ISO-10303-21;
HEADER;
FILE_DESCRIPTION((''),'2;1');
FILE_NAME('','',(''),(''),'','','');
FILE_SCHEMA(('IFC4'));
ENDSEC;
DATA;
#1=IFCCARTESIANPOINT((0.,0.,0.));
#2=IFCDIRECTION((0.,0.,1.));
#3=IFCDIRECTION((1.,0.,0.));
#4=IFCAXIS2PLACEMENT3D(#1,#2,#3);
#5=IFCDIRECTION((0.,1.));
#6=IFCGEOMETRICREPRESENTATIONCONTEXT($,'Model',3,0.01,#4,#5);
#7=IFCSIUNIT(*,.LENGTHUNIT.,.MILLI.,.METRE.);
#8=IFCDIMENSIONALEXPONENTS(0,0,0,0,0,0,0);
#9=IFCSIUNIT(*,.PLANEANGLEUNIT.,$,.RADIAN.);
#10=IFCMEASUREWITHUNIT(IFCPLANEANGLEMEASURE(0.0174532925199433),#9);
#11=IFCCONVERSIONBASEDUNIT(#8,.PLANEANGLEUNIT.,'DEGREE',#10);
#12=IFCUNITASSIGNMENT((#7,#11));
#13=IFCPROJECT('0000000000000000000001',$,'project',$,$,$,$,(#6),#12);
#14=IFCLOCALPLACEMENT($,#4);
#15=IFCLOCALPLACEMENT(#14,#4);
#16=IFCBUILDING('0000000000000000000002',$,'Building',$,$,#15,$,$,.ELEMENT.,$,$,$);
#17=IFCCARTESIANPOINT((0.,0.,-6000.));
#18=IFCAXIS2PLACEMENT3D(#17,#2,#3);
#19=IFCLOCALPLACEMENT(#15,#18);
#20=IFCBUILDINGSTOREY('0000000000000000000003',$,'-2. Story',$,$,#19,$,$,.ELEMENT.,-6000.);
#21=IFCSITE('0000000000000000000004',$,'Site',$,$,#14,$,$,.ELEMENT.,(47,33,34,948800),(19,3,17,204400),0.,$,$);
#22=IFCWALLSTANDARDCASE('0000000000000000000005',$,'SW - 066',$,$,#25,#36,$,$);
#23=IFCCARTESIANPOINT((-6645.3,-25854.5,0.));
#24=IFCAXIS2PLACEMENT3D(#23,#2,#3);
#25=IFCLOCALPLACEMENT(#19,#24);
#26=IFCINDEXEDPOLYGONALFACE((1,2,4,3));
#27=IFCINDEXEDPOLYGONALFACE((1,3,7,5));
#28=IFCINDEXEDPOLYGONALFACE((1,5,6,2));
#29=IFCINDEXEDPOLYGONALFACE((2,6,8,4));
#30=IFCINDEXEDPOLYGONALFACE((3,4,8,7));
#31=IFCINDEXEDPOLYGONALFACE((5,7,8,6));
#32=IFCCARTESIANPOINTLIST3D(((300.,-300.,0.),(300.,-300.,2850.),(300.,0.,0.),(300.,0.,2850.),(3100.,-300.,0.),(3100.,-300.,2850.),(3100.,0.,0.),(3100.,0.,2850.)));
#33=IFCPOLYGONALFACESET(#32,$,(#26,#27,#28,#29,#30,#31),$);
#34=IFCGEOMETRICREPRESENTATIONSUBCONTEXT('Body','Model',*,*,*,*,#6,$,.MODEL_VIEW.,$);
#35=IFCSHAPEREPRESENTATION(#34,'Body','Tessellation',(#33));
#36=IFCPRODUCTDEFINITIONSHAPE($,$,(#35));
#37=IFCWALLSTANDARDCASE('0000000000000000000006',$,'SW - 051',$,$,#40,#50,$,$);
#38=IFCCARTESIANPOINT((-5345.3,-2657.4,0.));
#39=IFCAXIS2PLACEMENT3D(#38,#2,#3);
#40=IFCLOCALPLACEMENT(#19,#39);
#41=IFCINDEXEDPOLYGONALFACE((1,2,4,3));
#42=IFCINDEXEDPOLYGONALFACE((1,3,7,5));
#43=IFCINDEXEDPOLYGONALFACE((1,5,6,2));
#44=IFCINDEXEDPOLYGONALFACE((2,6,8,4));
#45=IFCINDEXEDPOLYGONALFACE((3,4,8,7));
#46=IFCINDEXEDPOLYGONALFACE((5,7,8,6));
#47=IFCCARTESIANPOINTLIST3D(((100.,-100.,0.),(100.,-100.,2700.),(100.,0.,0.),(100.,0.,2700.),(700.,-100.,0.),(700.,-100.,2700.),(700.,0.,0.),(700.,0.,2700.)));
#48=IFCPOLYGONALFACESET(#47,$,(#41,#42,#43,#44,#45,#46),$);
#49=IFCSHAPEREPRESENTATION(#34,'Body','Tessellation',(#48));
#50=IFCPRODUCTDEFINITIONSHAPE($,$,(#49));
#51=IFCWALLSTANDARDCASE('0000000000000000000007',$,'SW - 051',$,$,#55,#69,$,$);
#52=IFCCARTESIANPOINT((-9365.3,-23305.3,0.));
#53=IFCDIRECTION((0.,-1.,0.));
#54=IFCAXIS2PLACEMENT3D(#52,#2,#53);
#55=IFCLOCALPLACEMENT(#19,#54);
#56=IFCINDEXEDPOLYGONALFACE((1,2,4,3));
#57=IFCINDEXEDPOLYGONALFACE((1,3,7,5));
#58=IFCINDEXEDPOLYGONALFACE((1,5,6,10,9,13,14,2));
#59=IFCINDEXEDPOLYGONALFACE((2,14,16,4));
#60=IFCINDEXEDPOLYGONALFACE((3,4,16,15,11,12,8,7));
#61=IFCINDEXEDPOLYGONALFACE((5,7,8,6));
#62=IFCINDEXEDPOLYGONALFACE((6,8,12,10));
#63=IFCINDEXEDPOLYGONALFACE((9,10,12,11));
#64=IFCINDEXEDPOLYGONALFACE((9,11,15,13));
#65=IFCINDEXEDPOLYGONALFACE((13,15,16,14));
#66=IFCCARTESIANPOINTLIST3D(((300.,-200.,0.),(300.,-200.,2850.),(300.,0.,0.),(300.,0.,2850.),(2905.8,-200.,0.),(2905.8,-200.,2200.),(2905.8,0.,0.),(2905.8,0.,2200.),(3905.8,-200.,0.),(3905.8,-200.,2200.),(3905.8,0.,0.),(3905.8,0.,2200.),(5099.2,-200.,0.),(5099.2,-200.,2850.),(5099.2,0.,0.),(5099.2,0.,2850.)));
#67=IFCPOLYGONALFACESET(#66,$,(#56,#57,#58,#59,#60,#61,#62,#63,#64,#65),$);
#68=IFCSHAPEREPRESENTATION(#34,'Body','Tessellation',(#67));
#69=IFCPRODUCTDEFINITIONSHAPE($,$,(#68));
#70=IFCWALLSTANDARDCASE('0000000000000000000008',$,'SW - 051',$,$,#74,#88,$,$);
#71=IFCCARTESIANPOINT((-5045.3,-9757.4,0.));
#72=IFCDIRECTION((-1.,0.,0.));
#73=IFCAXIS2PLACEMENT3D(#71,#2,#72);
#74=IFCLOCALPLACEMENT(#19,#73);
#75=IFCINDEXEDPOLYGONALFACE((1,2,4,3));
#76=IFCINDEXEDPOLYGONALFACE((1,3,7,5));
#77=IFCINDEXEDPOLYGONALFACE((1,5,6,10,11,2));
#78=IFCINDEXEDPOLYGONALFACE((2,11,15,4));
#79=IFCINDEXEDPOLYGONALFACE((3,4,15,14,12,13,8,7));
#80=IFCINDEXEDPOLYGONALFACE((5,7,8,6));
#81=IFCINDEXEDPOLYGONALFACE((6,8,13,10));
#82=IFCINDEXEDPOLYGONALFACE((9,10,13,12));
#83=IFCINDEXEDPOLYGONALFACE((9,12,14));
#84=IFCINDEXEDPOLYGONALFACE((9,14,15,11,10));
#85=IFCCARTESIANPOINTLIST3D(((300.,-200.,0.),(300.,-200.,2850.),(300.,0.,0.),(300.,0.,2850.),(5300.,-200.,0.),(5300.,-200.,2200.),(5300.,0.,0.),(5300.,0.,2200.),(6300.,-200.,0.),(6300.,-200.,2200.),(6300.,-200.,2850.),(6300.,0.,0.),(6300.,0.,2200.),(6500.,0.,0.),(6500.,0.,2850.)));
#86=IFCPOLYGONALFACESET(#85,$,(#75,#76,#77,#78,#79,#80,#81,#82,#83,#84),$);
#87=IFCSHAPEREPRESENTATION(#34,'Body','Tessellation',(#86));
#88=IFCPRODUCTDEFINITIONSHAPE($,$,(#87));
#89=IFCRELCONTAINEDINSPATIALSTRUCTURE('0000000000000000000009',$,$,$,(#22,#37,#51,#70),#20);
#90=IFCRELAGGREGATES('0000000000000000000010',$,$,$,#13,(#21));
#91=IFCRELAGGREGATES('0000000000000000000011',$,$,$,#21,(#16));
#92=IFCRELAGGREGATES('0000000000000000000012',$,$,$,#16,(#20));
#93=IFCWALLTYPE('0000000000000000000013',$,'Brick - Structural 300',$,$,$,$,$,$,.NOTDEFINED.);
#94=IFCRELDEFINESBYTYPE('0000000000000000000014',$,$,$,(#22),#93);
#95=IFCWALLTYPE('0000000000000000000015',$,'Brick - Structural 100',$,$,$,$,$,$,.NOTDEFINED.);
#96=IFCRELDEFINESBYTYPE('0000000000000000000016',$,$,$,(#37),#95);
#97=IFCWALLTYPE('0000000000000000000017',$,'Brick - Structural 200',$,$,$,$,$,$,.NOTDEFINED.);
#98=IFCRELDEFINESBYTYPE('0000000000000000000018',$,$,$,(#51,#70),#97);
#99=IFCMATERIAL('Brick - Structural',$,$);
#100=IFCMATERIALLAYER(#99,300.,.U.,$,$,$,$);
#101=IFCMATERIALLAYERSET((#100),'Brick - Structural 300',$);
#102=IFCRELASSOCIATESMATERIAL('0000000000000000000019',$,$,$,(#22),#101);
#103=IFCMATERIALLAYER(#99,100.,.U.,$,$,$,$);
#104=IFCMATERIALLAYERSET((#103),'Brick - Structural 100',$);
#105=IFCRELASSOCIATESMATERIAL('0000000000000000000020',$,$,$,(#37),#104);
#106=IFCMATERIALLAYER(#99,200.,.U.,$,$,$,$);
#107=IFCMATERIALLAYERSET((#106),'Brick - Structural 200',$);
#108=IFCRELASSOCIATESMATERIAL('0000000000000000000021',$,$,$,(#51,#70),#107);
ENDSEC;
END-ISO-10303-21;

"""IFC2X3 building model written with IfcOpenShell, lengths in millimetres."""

from ifc_helpers import new_model, entity, si_unit, converted_unit, direction, frame, origin_with_axes, origin_2d_with_axis, place, context, subcontext, project, spatial, polyline, rectangle, outline, extrude, material, layer, layer_set, layer_usage, type_object, element, save


model = new_model("IFC2X3")

# Units and contexts
model_context = context("Model", 3, precision=0.01, world=origin_with_axes(), true_north=direction((0.0, 1.0)))
body_context = subcontext(model_context, "Body", "Model", "MODEL_VIEW")
ifc_project = project(units=[si_unit("LENGTHUNIT", "METRE", prefix="MILLI"), converted_unit("PLANEANGLEUNIT", "DEGREE", entity("IfcPlaneAngleMeasure", 0.0174532925199433), si_unit("PLANEANGLEUNIT", "RADIAN"), dimensions=[0, 0, 0, 0, 0, 0, 0])], contexts=[model_context])

# Site, building, storey
site_placement = place(None, origin_with_axes())
site = spatial("IfcSite", under=ifc_project, at=site_placement, Name="Site", CompositionType="ELEMENT", RefLatitude=(47, 33, 34, 948800), RefLongitude=(19, 3, 17, 204400), RefElevation=0.0)
building_placement = place(site_placement, origin_with_axes())
building = spatial("IfcBuilding", under=site, at=building_placement, Name="Building", CompositionType="ELEMENT")
storey_placement = place(building_placement, frame((0.0, 0.0, -6000.0), z_axis=(0.0, 0.0, 1.0), x_axis=(1.0, 0.0, 0.0)))
storey = spatial("IfcBuildingStorey", under=building, at=storey_placement, Name="-2. Story", CompositionType="ELEMENT", Elevation=-6000.0)

# Wall
ifc_material_1 = material(Name="Brick - Structural")
ifc_layer_1 = layer(ifc_material_1, 300.0, ventilated="UNKNOWN")
ifc_layer_set_1 = layer_set([ifc_layer_1], Name="Brick - Structural 300")
wall_type_1 = type_object("IfcWallType", Name="Brick - Structural 300", PredefinedType="NOTDEFINED")
ifc_layer_usage_1 = layer_usage(ifc_layer_set_1, "AXIS2", "NEGATIVE", 0.0)
wall_1_placement = place(storey_placement, frame((-6645.3, -25854.5, 0.0), z_axis=(0.0, 0.0, 1.0), x_axis=(1.0, 0.0, 0.0)))
element("IfcWallStandardCase", 1, at=wall_1_placement, inside=storey, type_object=wall_type_1, material=ifc_layer_usage_1, Name="SW - 066", context=body_context, shape_type="SweptSolid", body=[
    extrude(outline(polyline([(300.0, -300.0), (3100.0, -300.0), (3100.0, 0.0), (300.0, 0.0), (300.0, -300.0)])), origin_with_axes(), (0.0, 0.0, 1.0), 2850.0),
])

# Wall
ifc_layer_2 = layer(ifc_material_1, 100.0, ventilated="UNKNOWN")
ifc_layer_set_2 = layer_set([ifc_layer_2], Name="Brick - Structural 100")
wall_type_2 = type_object("IfcWallType", Name="Brick - Structural 100", PredefinedType="NOTDEFINED")
ifc_layer_usage_2 = layer_usage(ifc_layer_set_2, "AXIS2", "NEGATIVE", 0.0)
wall_2_placement = place(storey_placement, frame((-5345.3, -2657.4, 0.0), z_axis=(0.0, 0.0, 1.0), x_axis=(1.0, 0.0, 0.0)))
element("IfcWallStandardCase", 2, at=wall_2_placement, inside=storey, type_object=wall_type_2, material=ifc_layer_usage_2, Name="SW - 051", context=body_context, shape_type="SweptSolid", body=[
    extrude(outline(polyline([(100.0, -100.0), (700.0, -100.0), (700.0, 0.0), (100.0, 0.0), (100.0, -100.0)])), origin_with_axes(), (0.0, 0.0, 1.0), 2700.0),
])

# Walls, openings
ifc_layer_3 = layer(ifc_material_1, 200.0, ventilated="UNKNOWN")
ifc_layer_set_3 = layer_set([ifc_layer_3], Name="Brick - Structural 200")
ifc_layer_usage_3 = layer_usage(ifc_layer_set_3, "AXIS2", "NEGATIVE", 0.0)
wall_type_3 = type_object("IfcWallType", Name="Brick - Structural 200", PredefinedType="NOTDEFINED")
wall_3_placement = place(storey_placement, frame((-9365.3, -23305.3, 0.0), z_axis=(0.0, 0.0, 1.0), x_axis=(0.0, -1.0, 0.0)))
wall_3 = element("IfcWallStandardCase", 3, at=wall_3_placement, inside=storey, type_object=wall_type_3, material=ifc_layer_usage_3, Name="SW - 051", context=body_context, shape_type="SweptSolid", body=[
    extrude(outline(polyline([(300.0, -200.0), (5099.2, -200.0), (5099.2, 0.0), (300.0, 0.0), (300.0, -200.0)])), origin_with_axes(), (0.0, 0.0, 1.0), 2850.0),
])
opening_1_placement = place(wall_3_placement, frame((3405.8, 0.0, 0.0), z_axis=(0.0, 0.0, 1.0), x_axis=(1.0, 0.0, 0.0)))
element("IfcOpeningElement", 4, at=opening_1_placement, cuts=wall_3, context=body_context, shape_type="SweptSolid", body=[
    extrude(rectangle(XDim=1000.0, YDim=2200.0, at=origin_2d_with_axis()), frame((0.0, 0.0, 1100.0), z_axis=(0.0, -1.0, 0.0), x_axis=(1.0, 0.0, 0.0)), (0.0, 0.0, -1.0), 200.0),
    extrude(rectangle(XDim=1000.0, YDim=2200.0, at=origin_2d_with_axis()), frame((0.0, 0.0, 1100.0), z_axis=(0.0, 1.0, 0.0), x_axis=(1.0, 0.0, 0.0)), (0.0, 0.0, -1.0), 200.0),
])
ifc_layer_usage_4 = layer_usage(ifc_layer_set_3, "AXIS2", "NEGATIVE", 0.0)
wall_4_placement = place(storey_placement, frame((-5045.3, -9757.4, 0.0), z_axis=(0.0, 0.0, 1.0), x_axis=(-1.0, 0.0, 0.0)))
wall_4 = element("IfcWallStandardCase", 5, at=wall_4_placement, inside=storey, type_object=wall_type_3, material=ifc_layer_usage_4, Name="SW - 051", context=body_context, shape_type="SweptSolid", body=[
    extrude(outline(polyline([(300.0, -200.0), (6300.0, -200.0), (6500.0, 0.0), (300.0, 0.0), (300.0, -200.0)])), origin_with_axes(), (0.0, 0.0, 1.0), 2850.0),
])
opening_2_placement = place(wall_4_placement, frame((5800.0, 0.0, 0.0), z_axis=(0.0, 0.0, 1.0), x_axis=(1.0, 0.0, 0.0)))
element("IfcOpeningElement", 6, at=opening_2_placement, cuts=wall_4, context=body_context, shape_type="SweptSolid", body=[
    extrude(rectangle(XDim=1000.0, YDim=2200.0, at=origin_2d_with_axis()), frame((0.0, -200.0, 1100.0), z_axis=(0.0, 1.0, 0.0), x_axis=(1.0, 0.0, 0.0)), (0.0, 0.0, -1.0), 200.0),
    extrude(rectangle(XDim=1000.0, YDim=2200.0, at=origin_2d_with_axis()), frame((0.0, -200.0, 1100.0), z_axis=(0.0, -1.0, 0.0), x_axis=(1.0, 0.0, 0.0)), (0.0, 0.0, -1.0), 200.0),
])

save(model, "model.ifc")
